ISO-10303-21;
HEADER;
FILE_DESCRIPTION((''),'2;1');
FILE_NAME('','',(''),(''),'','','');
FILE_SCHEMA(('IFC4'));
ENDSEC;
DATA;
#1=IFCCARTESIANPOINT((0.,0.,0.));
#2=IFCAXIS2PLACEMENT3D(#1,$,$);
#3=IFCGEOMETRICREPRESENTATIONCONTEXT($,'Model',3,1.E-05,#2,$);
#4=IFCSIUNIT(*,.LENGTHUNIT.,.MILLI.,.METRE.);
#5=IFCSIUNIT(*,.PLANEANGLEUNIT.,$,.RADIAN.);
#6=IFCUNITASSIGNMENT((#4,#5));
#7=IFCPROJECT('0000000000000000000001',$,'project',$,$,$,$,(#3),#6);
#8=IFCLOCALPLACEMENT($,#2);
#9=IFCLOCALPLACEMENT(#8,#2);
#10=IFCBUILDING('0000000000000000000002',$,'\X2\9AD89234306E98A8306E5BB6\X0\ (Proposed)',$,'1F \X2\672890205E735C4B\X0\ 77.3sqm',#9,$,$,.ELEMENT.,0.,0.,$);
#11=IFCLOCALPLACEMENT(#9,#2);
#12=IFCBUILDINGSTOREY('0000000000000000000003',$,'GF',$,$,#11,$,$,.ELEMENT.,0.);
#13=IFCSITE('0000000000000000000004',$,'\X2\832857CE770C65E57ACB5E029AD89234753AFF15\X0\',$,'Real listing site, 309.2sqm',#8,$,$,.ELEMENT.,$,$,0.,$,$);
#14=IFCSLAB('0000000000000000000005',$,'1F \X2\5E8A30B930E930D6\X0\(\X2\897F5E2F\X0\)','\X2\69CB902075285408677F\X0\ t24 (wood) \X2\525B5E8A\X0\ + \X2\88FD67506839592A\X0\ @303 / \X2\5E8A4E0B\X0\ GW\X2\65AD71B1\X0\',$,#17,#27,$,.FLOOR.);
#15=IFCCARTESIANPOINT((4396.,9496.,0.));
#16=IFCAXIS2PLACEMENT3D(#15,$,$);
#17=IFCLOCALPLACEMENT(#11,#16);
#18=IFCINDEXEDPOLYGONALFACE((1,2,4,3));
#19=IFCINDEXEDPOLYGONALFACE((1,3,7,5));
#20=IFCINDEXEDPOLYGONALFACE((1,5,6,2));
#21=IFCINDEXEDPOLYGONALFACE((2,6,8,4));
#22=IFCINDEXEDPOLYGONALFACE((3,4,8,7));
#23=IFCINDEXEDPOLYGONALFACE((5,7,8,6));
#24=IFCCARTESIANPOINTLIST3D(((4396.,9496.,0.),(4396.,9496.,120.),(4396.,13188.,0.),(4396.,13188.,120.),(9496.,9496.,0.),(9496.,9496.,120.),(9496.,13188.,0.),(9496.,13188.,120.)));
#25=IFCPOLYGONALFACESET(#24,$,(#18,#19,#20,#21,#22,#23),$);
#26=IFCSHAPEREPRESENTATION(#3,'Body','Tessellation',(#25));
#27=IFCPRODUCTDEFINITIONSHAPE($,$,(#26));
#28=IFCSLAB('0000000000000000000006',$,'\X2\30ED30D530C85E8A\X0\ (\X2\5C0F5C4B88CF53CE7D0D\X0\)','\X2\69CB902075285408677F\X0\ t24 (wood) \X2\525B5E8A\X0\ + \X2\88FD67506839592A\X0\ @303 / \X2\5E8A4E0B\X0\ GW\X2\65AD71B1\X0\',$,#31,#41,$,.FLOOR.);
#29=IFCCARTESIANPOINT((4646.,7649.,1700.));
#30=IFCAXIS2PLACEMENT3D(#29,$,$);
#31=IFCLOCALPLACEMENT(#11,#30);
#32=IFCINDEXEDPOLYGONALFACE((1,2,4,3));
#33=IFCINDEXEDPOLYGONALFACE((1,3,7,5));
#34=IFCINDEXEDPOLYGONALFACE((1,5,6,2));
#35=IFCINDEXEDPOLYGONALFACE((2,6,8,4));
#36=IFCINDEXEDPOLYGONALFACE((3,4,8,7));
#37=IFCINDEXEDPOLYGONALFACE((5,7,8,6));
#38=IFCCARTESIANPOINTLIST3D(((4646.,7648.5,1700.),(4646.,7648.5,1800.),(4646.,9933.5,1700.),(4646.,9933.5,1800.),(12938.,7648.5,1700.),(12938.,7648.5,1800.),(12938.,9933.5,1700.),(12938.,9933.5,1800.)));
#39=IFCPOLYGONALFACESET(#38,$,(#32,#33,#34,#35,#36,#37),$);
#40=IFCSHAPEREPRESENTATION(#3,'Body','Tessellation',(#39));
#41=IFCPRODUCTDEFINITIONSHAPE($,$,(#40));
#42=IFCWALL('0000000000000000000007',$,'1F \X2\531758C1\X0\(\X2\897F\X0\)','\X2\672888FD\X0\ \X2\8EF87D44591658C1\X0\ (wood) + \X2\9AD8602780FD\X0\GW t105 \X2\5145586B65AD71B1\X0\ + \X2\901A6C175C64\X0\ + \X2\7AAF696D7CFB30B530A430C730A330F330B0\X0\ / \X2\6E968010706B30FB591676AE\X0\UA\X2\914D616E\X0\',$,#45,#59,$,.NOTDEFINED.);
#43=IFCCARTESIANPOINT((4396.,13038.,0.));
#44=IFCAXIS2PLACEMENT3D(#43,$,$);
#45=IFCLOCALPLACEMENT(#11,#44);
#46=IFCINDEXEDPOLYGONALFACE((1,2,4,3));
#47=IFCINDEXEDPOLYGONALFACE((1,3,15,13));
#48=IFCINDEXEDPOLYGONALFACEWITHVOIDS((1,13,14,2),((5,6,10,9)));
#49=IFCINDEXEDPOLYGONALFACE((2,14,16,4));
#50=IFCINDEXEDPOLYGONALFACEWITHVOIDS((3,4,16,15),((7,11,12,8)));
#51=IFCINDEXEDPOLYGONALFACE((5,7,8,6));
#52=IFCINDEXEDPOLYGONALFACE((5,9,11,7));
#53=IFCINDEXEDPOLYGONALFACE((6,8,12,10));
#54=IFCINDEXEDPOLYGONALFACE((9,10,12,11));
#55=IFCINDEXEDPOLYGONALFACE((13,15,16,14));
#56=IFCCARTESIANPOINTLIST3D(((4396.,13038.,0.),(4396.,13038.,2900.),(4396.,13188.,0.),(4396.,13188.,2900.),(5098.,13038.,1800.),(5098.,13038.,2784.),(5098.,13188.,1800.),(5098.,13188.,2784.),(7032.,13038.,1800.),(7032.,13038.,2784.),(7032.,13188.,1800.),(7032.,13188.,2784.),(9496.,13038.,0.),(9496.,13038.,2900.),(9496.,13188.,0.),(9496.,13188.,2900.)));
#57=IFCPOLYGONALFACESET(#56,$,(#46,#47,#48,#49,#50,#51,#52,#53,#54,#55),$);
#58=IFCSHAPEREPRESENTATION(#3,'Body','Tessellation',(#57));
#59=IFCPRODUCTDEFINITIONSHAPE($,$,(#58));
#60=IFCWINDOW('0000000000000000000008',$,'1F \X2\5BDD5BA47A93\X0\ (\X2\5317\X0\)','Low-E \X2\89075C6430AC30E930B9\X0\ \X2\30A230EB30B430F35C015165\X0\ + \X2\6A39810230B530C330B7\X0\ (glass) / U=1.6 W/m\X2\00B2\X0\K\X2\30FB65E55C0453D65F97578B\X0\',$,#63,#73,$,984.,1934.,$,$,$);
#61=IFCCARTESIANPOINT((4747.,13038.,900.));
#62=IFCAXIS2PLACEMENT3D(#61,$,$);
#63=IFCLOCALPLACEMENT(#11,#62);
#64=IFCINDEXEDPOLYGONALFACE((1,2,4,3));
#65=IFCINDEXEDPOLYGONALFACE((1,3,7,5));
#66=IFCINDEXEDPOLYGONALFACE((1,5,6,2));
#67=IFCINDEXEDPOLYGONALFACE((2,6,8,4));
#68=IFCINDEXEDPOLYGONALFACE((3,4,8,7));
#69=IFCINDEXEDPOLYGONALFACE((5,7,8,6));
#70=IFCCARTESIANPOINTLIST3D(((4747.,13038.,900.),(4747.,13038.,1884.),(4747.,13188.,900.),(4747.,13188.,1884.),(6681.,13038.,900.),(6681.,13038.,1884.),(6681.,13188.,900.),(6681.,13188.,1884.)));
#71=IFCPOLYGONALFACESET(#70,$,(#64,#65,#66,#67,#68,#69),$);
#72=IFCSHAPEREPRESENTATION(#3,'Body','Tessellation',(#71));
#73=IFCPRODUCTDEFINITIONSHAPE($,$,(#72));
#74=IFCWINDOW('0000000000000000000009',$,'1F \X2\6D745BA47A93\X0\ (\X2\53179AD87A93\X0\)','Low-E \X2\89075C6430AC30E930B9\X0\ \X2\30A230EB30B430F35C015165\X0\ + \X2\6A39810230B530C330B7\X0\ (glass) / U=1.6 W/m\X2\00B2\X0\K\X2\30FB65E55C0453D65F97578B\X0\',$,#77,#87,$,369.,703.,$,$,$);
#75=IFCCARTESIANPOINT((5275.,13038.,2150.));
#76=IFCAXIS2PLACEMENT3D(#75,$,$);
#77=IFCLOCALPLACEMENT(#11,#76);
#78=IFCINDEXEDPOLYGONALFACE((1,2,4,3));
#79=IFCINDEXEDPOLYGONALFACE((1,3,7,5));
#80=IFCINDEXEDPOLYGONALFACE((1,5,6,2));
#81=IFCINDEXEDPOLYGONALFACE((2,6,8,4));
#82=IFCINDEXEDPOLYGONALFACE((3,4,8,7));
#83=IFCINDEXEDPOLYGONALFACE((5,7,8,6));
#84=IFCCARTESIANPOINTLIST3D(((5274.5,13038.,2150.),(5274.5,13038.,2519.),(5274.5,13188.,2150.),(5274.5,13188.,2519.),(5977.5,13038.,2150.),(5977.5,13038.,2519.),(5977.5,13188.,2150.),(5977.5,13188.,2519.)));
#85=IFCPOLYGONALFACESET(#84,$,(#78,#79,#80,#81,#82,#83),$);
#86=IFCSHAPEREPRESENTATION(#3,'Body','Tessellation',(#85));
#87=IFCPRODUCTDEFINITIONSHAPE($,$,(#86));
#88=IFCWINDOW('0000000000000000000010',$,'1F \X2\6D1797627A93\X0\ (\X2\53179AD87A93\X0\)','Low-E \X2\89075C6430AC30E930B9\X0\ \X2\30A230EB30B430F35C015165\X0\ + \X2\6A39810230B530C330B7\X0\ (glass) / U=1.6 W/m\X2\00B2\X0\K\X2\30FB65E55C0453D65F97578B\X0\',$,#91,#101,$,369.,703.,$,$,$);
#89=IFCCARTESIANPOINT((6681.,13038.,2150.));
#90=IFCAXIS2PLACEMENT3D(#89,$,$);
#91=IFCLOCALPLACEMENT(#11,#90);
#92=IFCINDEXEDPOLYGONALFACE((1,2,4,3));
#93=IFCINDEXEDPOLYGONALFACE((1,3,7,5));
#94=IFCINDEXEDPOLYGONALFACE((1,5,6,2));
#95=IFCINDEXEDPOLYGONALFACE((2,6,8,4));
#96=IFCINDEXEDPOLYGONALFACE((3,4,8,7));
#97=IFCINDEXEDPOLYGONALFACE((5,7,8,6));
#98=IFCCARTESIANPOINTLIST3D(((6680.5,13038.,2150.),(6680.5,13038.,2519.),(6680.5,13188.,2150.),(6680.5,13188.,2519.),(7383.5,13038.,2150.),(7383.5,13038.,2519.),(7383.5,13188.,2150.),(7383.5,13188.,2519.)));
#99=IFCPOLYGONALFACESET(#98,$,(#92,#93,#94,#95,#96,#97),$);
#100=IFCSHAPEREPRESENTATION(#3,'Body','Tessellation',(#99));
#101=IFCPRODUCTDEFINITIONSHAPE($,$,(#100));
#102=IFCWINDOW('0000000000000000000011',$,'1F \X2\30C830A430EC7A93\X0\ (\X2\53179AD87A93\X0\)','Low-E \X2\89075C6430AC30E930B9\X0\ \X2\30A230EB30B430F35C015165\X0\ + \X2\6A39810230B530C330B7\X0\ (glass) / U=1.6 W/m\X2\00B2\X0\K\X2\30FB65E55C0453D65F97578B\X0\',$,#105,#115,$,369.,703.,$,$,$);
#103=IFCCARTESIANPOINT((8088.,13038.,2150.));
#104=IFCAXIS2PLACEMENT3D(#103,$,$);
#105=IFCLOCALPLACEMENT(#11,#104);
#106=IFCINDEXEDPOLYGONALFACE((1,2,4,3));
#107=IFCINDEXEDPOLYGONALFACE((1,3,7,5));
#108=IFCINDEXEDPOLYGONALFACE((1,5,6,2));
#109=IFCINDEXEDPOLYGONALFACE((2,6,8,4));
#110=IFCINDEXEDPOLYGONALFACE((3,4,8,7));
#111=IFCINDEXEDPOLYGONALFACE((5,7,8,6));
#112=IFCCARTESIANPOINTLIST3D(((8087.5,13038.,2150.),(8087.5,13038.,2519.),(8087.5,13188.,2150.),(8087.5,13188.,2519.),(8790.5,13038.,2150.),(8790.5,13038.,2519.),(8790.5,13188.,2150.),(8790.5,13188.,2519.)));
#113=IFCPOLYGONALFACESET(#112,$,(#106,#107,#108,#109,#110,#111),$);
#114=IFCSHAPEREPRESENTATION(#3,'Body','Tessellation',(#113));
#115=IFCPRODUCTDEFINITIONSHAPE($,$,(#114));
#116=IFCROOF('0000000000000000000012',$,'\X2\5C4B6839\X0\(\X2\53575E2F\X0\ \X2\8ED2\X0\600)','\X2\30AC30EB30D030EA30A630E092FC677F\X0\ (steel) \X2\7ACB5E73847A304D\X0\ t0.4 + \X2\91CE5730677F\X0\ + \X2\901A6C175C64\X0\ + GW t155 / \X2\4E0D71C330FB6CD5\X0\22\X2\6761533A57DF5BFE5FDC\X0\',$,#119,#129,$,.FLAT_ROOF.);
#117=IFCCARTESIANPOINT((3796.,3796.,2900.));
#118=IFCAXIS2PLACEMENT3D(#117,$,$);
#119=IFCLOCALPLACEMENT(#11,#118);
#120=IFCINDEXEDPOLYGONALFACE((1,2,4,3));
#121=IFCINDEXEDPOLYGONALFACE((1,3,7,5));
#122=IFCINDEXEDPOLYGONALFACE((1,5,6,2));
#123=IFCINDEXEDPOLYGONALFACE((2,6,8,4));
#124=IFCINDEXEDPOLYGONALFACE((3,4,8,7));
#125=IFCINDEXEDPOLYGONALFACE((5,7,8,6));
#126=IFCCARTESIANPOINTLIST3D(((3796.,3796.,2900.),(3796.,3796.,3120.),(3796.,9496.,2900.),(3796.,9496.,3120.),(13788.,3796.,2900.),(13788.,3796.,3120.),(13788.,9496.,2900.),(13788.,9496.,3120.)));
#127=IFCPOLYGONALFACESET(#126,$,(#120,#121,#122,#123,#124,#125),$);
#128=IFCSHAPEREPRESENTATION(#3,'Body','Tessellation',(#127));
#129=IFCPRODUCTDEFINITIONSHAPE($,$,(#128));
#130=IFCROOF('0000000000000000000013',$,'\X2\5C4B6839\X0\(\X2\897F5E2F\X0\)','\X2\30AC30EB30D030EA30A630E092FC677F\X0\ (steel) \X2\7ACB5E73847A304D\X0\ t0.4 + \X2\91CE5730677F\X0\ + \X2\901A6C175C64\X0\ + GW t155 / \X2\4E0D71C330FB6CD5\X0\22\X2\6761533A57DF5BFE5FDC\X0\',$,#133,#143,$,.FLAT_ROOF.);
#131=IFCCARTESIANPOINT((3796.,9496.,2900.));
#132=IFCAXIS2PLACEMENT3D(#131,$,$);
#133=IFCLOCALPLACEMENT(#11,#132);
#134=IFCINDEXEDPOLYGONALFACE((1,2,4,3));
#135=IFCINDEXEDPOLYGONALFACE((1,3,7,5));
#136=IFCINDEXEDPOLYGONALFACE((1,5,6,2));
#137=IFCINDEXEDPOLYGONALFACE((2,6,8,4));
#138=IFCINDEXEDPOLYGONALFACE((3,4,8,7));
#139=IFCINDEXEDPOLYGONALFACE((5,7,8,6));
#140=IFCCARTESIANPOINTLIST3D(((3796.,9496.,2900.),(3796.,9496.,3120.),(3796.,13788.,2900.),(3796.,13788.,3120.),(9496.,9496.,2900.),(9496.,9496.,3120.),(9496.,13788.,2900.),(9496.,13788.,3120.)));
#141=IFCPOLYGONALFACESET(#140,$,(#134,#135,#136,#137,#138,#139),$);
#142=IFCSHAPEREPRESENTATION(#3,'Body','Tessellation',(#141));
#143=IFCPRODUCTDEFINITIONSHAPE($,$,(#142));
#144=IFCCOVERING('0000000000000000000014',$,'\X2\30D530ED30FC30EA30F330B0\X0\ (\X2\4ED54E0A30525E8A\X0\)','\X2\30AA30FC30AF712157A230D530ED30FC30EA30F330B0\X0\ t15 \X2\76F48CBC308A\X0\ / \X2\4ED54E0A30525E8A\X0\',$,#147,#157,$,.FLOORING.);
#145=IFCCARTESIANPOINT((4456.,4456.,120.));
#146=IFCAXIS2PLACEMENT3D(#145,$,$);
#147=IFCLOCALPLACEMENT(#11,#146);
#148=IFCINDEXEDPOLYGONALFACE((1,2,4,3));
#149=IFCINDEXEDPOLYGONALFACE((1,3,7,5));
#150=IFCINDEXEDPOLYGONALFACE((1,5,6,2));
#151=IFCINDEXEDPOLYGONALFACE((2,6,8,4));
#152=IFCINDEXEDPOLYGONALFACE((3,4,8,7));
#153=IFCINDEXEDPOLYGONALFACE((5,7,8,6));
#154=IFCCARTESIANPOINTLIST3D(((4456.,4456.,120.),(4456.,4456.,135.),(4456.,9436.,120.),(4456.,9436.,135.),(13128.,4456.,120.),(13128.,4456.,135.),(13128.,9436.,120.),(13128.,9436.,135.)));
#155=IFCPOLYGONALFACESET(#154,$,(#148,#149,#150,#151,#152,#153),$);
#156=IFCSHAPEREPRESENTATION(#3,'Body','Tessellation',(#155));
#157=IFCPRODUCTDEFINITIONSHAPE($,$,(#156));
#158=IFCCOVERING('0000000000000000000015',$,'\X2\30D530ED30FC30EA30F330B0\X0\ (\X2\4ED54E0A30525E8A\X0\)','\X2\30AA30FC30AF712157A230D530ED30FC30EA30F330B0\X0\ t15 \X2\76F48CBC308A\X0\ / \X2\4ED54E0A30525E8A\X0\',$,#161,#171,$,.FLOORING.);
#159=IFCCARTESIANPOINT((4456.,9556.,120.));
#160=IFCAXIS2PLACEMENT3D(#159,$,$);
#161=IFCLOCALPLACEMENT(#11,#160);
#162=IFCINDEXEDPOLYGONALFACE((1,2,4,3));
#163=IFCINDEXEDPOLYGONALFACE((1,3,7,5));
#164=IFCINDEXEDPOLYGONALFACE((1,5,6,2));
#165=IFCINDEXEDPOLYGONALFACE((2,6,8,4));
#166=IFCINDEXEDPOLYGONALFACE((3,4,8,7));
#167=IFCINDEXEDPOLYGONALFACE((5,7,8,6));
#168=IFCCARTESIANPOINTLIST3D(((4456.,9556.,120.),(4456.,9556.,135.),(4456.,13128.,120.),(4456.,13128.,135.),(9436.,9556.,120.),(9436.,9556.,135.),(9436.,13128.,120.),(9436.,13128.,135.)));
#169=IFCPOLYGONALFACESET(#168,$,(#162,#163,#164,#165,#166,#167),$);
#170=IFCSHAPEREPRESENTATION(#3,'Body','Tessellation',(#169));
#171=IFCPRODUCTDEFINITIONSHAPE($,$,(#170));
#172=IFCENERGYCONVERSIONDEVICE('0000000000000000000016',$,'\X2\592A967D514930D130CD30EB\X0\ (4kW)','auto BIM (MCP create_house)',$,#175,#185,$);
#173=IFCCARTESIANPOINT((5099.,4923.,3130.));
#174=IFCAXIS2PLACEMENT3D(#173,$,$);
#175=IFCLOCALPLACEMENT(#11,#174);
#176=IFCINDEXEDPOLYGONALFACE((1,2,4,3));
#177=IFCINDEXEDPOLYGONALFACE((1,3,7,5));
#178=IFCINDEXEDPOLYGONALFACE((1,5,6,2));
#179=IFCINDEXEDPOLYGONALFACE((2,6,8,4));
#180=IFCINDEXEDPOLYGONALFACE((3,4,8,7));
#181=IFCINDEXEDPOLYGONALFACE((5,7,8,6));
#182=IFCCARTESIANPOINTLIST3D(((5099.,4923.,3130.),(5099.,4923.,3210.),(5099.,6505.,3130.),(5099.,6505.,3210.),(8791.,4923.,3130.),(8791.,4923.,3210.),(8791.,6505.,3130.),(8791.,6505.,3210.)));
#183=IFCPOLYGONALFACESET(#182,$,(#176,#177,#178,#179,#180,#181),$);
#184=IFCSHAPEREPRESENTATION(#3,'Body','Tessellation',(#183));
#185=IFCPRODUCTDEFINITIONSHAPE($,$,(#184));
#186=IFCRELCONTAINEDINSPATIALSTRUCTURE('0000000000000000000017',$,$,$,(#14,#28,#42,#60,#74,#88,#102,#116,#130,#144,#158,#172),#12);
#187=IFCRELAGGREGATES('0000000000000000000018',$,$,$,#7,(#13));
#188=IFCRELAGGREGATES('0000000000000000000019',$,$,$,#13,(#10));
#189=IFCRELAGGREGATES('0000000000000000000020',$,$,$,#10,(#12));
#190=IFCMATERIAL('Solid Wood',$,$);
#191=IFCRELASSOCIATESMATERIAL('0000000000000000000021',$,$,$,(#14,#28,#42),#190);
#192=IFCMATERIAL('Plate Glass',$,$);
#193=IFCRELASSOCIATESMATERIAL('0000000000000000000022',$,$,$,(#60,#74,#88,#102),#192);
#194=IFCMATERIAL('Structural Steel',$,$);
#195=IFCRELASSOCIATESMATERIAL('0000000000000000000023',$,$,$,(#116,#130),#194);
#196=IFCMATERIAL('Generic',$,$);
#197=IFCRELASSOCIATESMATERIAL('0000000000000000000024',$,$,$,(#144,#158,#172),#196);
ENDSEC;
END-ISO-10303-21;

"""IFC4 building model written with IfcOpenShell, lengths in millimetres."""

from ifc_helpers import new_model, si_unit, frame, frame_2d, origin, place, context, project, spatial, rectangle, extrude, material, element, fill, save


model = new_model("IFC4")

# Units and contexts
model_context = context("Model", 3, precision=1e-05, world=origin())
ifc_project = project(units=[si_unit("LENGTHUNIT", "METRE", prefix="MILLI"), si_unit("PLANEANGLEUNIT", "RADIAN")], contexts=[model_context])

# Site, building, storey
site_placement = place(None, origin())
site = spatial("IfcSite", under=ifc_project, at=site_placement, Name="茨城県日立市高鈴町５", ObjectType="Real listing site, 309.2sqm", CompositionType="ELEMENT", RefElevation=0.0)
building_placement = place(site_placement, origin())
building = spatial("IfcBuilding", under=site, at=building_placement, Name="高鈴の風の家 (Proposed)", ObjectType="1F 木造平屋 77.3sqm", CompositionType="ELEMENT", ElevationOfRefHeight=0.0, ElevationOfTerrain=0.0)
storey_placement = place(building_placement, origin())
storey = spatial("IfcBuildingStorey", under=building, at=storey_placement, Name="GF", CompositionType="ELEMENT", Elevation=0.0)

# Slabs
ifc_material_1 = material(Name="Solid Wood")
slab_1_placement = place(storey_placement, frame((4396.0, 9496.0, 0.0)))
element("IfcSlab", 1, at=slab_1_placement, inside=storey, material=ifc_material_1, Name="1F 床スラブ(西帯)", Description="構造用合板 t24 (wood) 剛床 + 製材根太 @303 / 床下 GW断熱", PredefinedType="FLOOR", context=model_context, shape_type="SweptSolid", body=[
    extrude(rectangle(XDim=5100.0, YDim=3692.0, at=frame_2d((2550.0, 1846.0))), frame((4396.0, 9496.0, 0.0)), (0.0, 0.0, 1.0), 120.0),
])
slab_2_placement = place(storey_placement, frame((4646.0, 7649.0, 1700.0)))
element("IfcSlab", 2, at=slab_2_placement, inside=storey, material=ifc_material_1, Name="ロフト床 (小屋裏収納)", Description="構造用合板 t24 (wood) 剛床 + 製材根太 @303 / 床下 GW断熱", PredefinedType="FLOOR", context=model_context, shape_type="SweptSolid", body=[
    extrude(rectangle(XDim=8292.0, YDim=2285.0, at=frame_2d((4146.0, 1142.0))), frame((4646.0, 7649.0, 1700.0)), (0.0, 0.0, 1.0), 100.0),
])

# Shared definitions
ifc_material_2 = material(Name="Plate Glass")

# Wall, openings, windows
wall_1_placement = place(storey_placement, frame((4396.0, 13038.0, 0.0)))
wall_1 = element("IfcWall", 3, at=wall_1_placement, inside=storey, material=ifc_material_1, Name="1F 北壁(西)", Description="木製 軸組外壁 (wood) + 高性能GW t105 充填断熱 + 通気層 + 窯業系サイディング / 準耐火・外皮UA配慮", PredefinedType="NOTDEFINED", context=model_context, shape_type="SweptSolid", body=[
    extrude(rectangle(XDim=5100.0, YDim=150.0, at=frame_2d((2550.0, 75.0))), frame((4396.0, 13038.0, 0.0)), (0.0, 0.0, 1.0), 2900.0),
])
opening_1_placement = place(storey_placement, frame((4747.0, 13038.0, 900.0)))
opening_1 = element("IfcOpeningElement", 4, at=opening_1_placement, cuts=wall_1, PredefinedType="NOTDEFINED", context=model_context, shape_type="SweptSolid", body=[
    extrude(rectangle(XDim=1934.0, YDim=150.0, at=frame_2d((967.0, 75.0))), frame((4747.0, 13038.0, 900.0)), (0.0, 0.0, 1.0), 984.0),
])
opening_2_placement = place(storey_placement, frame((5275.0, 13038.0, 2150.0)))
opening_2 = element("IfcOpeningElement", 5, at=opening_2_placement, cuts=wall_1, PredefinedType="NOTDEFINED", context=model_context, shape_type="SweptSolid", body=[
    extrude(rectangle(XDim=703.0, YDim=150.0, at=frame_2d((351.0, 75.0))), frame((5275.0, 13038.0, 2150.0)), (0.0, 0.0, 1.0), 369.0),
])
opening_3_placement = place(storey_placement, frame((6681.0, 13038.0, 2150.0)))
opening_3 = element("IfcOpeningElement", 6, at=opening_3_placement, cuts=wall_1, PredefinedType="NOTDEFINED", context=model_context, shape_type="SweptSolid", body=[
    extrude(rectangle(XDim=703.0, YDim=150.0, at=frame_2d((351.0, 75.0))), frame((6681.0, 13038.0, 2150.0)), (0.0, 0.0, 1.0), 369.0),
])
opening_4_placement = place(storey_placement, frame((8088.0, 13038.0, 2150.0)))
opening_4 = element("IfcOpeningElement", 7, at=opening_4_placement, cuts=wall_1, PredefinedType="NOTDEFINED", context=model_context, shape_type="SweptSolid", body=[
    extrude(rectangle(XDim=703.0, YDim=150.0, at=frame_2d((351.0, 75.0))), frame((8088.0, 13038.0, 2150.0)), (0.0, 0.0, 1.0), 369.0),
])
window_1_placement = place(storey_placement, frame((4747.0, 13038.0, 900.0)))
window_1 = element("IfcWindow", 8, at=window_1_placement, inside=storey, material=ifc_material_2, Name="1F 寝室窓 (北)", Description="Low-E 複層ガラス アルゴン封入 + 樹脂サッシ (glass) / U=1.6 W/m²K・日射取得型", OverallHeight=984.0, OverallWidth=1934.0, context=model_context, shape_type="SweptSolid", body=[
    extrude(rectangle(XDim=1934.0, YDim=150.0, at=frame_2d((967.0, 75.0))), frame((4747.0, 13038.0, 900.0)), (0.0, 0.0, 1.0), 984.0),
])
fill(opening_1, window_1)
window_2_placement = place(storey_placement, frame((5275.0, 13038.0, 2150.0)))
window_2 = element("IfcWindow", 9, at=window_2_placement, inside=storey, material=ifc_material_2, Name="1F 浴室窓 (北高窓)", Description="Low-E 複層ガラス アルゴン封入 + 樹脂サッシ (glass) / U=1.6 W/m²K・日射取得型", OverallHeight=369.0, OverallWidth=703.0, context=model_context, shape_type="SweptSolid", body=[
    extrude(rectangle(XDim=703.0, YDim=150.0, at=frame_2d((351.0, 75.0))), frame((5275.0, 13038.0, 2150.0)), (0.0, 0.0, 1.0), 369.0),
])
fill(opening_2, window_2)
window_3_placement = place(storey_placement, frame((6681.0, 13038.0, 2150.0)))
window_3 = element("IfcWindow", 10, at=window_3_placement, inside=storey, material=ifc_material_2, Name="1F 洗面窓 (北高窓)", Description="Low-E 複層ガラス アルゴン封入 + 樹脂サッシ (glass) / U=1.6 W/m²K・日射取得型", OverallHeight=369.0, OverallWidth=703.0, context=model_context, shape_type="SweptSolid", body=[
    extrude(rectangle(XDim=703.0, YDim=150.0, at=frame_2d((351.0, 75.0))), frame((6681.0, 13038.0, 2150.0)), (0.0, 0.0, 1.0), 369.0),
])
fill(opening_3, window_3)
window_4_placement = place(storey_placement, frame((8088.0, 13038.0, 2150.0)))
window_4 = element("IfcWindow", 11, at=window_4_placement, inside=storey, material=ifc_material_2, Name="1F トイレ窓 (北高窓)", Description="Low-E 複層ガラス アルゴン封入 + 樹脂サッシ (glass) / U=1.6 W/m²K・日射取得型", OverallHeight=369.0, OverallWidth=703.0, context=model_context, shape_type="SweptSolid", body=[
    extrude(rectangle(XDim=703.0, YDim=150.0, at=frame_2d((351.0, 75.0))), frame((8088.0, 13038.0, 2150.0)), (0.0, 0.0, 1.0), 369.0),
])
fill(opening_4, window_4)

# Roofs
ifc_material_3 = material(Name="Structural Steel")
roof_1_placement = place(storey_placement, frame((3796.0, 3796.0, 2900.0)))
element("IfcRoof", 12, at=roof_1_placement, inside=storey, material=ifc_material_3, Name="屋根(南帯 軒600)", Description="ガルバリウム鋼板 (steel) 立平葺き t0.4 + 野地板 + 通気層 + GW t155 / 不燃・法22条区域対応", PredefinedType="FLAT_ROOF", context=model_context, shape_type="SweptSolid", body=[
    extrude(rectangle(XDim=9992.0, YDim=5700.0, at=frame_2d((4996.0, 2850.0))), frame((3796.0, 3796.0, 2900.0)), (0.0, 0.0, 1.0), 220.0),
])
roof_2_placement = place(storey_placement, frame((3796.0, 9496.0, 2900.0)))
element("IfcRoof", 13, at=roof_2_placement, inside=storey, material=ifc_material_3, Name="屋根(西帯)", Description="ガルバリウム鋼板 (steel) 立平葺き t0.4 + 野地板 + 通気層 + GW t155 / 不燃・法22条区域対応", PredefinedType="FLAT_ROOF", context=model_context, shape_type="SweptSolid", body=[
    extrude(rectangle(XDim=5700.0, YDim=4292.0, at=frame_2d((2850.0, 2146.0))), frame((3796.0, 9496.0, 2900.0)), (0.0, 0.0, 1.0), 220.0),
])

# Coverings
ifc_material_4 = material(Name="Generic")
covering_1_placement = place(storey_placement, frame((4456.0, 4456.0, 120.0)))
element("IfcCovering", 14, at=covering_1_placement, inside=storey, material=ifc_material_4, Name="フローリング (仕上げ床)", Description="オーク無垢フローリング t15 直貼り / 仕上げ床", PredefinedType="FLOORING", context=model_context, shape_type="SweptSolid", body=[
    extrude(rectangle(XDim=8672.0, YDim=4980.0, at=frame_2d((4336.0, 2490.0))), frame((4456.0, 4456.0, 120.0)), (0.0, 0.0, 1.0), 15.0),
])
covering_2_placement = place(storey_placement, frame((4456.0, 9556.0, 120.0)))
element("IfcCovering", 15, at=covering_2_placement, inside=storey, material=ifc_material_4, Name="フローリング (仕上げ床)", Description="オーク無垢フローリング t15 直貼り / 仕上げ床", PredefinedType="FLOORING", context=model_context, shape_type="SweptSolid", body=[
    extrude(rectangle(XDim=4980.0, YDim=3572.0, at=frame_2d((2490.0, 1786.0))), frame((4456.0, 9556.0, 120.0)), (0.0, 0.0, 1.0), 15.0),
])

# Energy conversion device
energy_conversion_device_placement = place(storey_placement, frame((5099.0, 4923.0, 3130.0)))
element("IfcEnergyConversionDevice", 16, at=energy_conversion_device_placement, inside=storey, material=ifc_material_4, Name="太陽光パネル (4kW)", Description="auto BIM (MCP create_house)", context=model_context, shape_type="SweptSolid", body=[
    extrude(rectangle(XDim=3692.0, YDim=1582.0, at=frame_2d((1846.0, 791.0))), frame((5099.0, 4923.0, 3130.0)), (0.0, 0.0, 1.0), 80.0),
])

save(model, "model.ifc")
